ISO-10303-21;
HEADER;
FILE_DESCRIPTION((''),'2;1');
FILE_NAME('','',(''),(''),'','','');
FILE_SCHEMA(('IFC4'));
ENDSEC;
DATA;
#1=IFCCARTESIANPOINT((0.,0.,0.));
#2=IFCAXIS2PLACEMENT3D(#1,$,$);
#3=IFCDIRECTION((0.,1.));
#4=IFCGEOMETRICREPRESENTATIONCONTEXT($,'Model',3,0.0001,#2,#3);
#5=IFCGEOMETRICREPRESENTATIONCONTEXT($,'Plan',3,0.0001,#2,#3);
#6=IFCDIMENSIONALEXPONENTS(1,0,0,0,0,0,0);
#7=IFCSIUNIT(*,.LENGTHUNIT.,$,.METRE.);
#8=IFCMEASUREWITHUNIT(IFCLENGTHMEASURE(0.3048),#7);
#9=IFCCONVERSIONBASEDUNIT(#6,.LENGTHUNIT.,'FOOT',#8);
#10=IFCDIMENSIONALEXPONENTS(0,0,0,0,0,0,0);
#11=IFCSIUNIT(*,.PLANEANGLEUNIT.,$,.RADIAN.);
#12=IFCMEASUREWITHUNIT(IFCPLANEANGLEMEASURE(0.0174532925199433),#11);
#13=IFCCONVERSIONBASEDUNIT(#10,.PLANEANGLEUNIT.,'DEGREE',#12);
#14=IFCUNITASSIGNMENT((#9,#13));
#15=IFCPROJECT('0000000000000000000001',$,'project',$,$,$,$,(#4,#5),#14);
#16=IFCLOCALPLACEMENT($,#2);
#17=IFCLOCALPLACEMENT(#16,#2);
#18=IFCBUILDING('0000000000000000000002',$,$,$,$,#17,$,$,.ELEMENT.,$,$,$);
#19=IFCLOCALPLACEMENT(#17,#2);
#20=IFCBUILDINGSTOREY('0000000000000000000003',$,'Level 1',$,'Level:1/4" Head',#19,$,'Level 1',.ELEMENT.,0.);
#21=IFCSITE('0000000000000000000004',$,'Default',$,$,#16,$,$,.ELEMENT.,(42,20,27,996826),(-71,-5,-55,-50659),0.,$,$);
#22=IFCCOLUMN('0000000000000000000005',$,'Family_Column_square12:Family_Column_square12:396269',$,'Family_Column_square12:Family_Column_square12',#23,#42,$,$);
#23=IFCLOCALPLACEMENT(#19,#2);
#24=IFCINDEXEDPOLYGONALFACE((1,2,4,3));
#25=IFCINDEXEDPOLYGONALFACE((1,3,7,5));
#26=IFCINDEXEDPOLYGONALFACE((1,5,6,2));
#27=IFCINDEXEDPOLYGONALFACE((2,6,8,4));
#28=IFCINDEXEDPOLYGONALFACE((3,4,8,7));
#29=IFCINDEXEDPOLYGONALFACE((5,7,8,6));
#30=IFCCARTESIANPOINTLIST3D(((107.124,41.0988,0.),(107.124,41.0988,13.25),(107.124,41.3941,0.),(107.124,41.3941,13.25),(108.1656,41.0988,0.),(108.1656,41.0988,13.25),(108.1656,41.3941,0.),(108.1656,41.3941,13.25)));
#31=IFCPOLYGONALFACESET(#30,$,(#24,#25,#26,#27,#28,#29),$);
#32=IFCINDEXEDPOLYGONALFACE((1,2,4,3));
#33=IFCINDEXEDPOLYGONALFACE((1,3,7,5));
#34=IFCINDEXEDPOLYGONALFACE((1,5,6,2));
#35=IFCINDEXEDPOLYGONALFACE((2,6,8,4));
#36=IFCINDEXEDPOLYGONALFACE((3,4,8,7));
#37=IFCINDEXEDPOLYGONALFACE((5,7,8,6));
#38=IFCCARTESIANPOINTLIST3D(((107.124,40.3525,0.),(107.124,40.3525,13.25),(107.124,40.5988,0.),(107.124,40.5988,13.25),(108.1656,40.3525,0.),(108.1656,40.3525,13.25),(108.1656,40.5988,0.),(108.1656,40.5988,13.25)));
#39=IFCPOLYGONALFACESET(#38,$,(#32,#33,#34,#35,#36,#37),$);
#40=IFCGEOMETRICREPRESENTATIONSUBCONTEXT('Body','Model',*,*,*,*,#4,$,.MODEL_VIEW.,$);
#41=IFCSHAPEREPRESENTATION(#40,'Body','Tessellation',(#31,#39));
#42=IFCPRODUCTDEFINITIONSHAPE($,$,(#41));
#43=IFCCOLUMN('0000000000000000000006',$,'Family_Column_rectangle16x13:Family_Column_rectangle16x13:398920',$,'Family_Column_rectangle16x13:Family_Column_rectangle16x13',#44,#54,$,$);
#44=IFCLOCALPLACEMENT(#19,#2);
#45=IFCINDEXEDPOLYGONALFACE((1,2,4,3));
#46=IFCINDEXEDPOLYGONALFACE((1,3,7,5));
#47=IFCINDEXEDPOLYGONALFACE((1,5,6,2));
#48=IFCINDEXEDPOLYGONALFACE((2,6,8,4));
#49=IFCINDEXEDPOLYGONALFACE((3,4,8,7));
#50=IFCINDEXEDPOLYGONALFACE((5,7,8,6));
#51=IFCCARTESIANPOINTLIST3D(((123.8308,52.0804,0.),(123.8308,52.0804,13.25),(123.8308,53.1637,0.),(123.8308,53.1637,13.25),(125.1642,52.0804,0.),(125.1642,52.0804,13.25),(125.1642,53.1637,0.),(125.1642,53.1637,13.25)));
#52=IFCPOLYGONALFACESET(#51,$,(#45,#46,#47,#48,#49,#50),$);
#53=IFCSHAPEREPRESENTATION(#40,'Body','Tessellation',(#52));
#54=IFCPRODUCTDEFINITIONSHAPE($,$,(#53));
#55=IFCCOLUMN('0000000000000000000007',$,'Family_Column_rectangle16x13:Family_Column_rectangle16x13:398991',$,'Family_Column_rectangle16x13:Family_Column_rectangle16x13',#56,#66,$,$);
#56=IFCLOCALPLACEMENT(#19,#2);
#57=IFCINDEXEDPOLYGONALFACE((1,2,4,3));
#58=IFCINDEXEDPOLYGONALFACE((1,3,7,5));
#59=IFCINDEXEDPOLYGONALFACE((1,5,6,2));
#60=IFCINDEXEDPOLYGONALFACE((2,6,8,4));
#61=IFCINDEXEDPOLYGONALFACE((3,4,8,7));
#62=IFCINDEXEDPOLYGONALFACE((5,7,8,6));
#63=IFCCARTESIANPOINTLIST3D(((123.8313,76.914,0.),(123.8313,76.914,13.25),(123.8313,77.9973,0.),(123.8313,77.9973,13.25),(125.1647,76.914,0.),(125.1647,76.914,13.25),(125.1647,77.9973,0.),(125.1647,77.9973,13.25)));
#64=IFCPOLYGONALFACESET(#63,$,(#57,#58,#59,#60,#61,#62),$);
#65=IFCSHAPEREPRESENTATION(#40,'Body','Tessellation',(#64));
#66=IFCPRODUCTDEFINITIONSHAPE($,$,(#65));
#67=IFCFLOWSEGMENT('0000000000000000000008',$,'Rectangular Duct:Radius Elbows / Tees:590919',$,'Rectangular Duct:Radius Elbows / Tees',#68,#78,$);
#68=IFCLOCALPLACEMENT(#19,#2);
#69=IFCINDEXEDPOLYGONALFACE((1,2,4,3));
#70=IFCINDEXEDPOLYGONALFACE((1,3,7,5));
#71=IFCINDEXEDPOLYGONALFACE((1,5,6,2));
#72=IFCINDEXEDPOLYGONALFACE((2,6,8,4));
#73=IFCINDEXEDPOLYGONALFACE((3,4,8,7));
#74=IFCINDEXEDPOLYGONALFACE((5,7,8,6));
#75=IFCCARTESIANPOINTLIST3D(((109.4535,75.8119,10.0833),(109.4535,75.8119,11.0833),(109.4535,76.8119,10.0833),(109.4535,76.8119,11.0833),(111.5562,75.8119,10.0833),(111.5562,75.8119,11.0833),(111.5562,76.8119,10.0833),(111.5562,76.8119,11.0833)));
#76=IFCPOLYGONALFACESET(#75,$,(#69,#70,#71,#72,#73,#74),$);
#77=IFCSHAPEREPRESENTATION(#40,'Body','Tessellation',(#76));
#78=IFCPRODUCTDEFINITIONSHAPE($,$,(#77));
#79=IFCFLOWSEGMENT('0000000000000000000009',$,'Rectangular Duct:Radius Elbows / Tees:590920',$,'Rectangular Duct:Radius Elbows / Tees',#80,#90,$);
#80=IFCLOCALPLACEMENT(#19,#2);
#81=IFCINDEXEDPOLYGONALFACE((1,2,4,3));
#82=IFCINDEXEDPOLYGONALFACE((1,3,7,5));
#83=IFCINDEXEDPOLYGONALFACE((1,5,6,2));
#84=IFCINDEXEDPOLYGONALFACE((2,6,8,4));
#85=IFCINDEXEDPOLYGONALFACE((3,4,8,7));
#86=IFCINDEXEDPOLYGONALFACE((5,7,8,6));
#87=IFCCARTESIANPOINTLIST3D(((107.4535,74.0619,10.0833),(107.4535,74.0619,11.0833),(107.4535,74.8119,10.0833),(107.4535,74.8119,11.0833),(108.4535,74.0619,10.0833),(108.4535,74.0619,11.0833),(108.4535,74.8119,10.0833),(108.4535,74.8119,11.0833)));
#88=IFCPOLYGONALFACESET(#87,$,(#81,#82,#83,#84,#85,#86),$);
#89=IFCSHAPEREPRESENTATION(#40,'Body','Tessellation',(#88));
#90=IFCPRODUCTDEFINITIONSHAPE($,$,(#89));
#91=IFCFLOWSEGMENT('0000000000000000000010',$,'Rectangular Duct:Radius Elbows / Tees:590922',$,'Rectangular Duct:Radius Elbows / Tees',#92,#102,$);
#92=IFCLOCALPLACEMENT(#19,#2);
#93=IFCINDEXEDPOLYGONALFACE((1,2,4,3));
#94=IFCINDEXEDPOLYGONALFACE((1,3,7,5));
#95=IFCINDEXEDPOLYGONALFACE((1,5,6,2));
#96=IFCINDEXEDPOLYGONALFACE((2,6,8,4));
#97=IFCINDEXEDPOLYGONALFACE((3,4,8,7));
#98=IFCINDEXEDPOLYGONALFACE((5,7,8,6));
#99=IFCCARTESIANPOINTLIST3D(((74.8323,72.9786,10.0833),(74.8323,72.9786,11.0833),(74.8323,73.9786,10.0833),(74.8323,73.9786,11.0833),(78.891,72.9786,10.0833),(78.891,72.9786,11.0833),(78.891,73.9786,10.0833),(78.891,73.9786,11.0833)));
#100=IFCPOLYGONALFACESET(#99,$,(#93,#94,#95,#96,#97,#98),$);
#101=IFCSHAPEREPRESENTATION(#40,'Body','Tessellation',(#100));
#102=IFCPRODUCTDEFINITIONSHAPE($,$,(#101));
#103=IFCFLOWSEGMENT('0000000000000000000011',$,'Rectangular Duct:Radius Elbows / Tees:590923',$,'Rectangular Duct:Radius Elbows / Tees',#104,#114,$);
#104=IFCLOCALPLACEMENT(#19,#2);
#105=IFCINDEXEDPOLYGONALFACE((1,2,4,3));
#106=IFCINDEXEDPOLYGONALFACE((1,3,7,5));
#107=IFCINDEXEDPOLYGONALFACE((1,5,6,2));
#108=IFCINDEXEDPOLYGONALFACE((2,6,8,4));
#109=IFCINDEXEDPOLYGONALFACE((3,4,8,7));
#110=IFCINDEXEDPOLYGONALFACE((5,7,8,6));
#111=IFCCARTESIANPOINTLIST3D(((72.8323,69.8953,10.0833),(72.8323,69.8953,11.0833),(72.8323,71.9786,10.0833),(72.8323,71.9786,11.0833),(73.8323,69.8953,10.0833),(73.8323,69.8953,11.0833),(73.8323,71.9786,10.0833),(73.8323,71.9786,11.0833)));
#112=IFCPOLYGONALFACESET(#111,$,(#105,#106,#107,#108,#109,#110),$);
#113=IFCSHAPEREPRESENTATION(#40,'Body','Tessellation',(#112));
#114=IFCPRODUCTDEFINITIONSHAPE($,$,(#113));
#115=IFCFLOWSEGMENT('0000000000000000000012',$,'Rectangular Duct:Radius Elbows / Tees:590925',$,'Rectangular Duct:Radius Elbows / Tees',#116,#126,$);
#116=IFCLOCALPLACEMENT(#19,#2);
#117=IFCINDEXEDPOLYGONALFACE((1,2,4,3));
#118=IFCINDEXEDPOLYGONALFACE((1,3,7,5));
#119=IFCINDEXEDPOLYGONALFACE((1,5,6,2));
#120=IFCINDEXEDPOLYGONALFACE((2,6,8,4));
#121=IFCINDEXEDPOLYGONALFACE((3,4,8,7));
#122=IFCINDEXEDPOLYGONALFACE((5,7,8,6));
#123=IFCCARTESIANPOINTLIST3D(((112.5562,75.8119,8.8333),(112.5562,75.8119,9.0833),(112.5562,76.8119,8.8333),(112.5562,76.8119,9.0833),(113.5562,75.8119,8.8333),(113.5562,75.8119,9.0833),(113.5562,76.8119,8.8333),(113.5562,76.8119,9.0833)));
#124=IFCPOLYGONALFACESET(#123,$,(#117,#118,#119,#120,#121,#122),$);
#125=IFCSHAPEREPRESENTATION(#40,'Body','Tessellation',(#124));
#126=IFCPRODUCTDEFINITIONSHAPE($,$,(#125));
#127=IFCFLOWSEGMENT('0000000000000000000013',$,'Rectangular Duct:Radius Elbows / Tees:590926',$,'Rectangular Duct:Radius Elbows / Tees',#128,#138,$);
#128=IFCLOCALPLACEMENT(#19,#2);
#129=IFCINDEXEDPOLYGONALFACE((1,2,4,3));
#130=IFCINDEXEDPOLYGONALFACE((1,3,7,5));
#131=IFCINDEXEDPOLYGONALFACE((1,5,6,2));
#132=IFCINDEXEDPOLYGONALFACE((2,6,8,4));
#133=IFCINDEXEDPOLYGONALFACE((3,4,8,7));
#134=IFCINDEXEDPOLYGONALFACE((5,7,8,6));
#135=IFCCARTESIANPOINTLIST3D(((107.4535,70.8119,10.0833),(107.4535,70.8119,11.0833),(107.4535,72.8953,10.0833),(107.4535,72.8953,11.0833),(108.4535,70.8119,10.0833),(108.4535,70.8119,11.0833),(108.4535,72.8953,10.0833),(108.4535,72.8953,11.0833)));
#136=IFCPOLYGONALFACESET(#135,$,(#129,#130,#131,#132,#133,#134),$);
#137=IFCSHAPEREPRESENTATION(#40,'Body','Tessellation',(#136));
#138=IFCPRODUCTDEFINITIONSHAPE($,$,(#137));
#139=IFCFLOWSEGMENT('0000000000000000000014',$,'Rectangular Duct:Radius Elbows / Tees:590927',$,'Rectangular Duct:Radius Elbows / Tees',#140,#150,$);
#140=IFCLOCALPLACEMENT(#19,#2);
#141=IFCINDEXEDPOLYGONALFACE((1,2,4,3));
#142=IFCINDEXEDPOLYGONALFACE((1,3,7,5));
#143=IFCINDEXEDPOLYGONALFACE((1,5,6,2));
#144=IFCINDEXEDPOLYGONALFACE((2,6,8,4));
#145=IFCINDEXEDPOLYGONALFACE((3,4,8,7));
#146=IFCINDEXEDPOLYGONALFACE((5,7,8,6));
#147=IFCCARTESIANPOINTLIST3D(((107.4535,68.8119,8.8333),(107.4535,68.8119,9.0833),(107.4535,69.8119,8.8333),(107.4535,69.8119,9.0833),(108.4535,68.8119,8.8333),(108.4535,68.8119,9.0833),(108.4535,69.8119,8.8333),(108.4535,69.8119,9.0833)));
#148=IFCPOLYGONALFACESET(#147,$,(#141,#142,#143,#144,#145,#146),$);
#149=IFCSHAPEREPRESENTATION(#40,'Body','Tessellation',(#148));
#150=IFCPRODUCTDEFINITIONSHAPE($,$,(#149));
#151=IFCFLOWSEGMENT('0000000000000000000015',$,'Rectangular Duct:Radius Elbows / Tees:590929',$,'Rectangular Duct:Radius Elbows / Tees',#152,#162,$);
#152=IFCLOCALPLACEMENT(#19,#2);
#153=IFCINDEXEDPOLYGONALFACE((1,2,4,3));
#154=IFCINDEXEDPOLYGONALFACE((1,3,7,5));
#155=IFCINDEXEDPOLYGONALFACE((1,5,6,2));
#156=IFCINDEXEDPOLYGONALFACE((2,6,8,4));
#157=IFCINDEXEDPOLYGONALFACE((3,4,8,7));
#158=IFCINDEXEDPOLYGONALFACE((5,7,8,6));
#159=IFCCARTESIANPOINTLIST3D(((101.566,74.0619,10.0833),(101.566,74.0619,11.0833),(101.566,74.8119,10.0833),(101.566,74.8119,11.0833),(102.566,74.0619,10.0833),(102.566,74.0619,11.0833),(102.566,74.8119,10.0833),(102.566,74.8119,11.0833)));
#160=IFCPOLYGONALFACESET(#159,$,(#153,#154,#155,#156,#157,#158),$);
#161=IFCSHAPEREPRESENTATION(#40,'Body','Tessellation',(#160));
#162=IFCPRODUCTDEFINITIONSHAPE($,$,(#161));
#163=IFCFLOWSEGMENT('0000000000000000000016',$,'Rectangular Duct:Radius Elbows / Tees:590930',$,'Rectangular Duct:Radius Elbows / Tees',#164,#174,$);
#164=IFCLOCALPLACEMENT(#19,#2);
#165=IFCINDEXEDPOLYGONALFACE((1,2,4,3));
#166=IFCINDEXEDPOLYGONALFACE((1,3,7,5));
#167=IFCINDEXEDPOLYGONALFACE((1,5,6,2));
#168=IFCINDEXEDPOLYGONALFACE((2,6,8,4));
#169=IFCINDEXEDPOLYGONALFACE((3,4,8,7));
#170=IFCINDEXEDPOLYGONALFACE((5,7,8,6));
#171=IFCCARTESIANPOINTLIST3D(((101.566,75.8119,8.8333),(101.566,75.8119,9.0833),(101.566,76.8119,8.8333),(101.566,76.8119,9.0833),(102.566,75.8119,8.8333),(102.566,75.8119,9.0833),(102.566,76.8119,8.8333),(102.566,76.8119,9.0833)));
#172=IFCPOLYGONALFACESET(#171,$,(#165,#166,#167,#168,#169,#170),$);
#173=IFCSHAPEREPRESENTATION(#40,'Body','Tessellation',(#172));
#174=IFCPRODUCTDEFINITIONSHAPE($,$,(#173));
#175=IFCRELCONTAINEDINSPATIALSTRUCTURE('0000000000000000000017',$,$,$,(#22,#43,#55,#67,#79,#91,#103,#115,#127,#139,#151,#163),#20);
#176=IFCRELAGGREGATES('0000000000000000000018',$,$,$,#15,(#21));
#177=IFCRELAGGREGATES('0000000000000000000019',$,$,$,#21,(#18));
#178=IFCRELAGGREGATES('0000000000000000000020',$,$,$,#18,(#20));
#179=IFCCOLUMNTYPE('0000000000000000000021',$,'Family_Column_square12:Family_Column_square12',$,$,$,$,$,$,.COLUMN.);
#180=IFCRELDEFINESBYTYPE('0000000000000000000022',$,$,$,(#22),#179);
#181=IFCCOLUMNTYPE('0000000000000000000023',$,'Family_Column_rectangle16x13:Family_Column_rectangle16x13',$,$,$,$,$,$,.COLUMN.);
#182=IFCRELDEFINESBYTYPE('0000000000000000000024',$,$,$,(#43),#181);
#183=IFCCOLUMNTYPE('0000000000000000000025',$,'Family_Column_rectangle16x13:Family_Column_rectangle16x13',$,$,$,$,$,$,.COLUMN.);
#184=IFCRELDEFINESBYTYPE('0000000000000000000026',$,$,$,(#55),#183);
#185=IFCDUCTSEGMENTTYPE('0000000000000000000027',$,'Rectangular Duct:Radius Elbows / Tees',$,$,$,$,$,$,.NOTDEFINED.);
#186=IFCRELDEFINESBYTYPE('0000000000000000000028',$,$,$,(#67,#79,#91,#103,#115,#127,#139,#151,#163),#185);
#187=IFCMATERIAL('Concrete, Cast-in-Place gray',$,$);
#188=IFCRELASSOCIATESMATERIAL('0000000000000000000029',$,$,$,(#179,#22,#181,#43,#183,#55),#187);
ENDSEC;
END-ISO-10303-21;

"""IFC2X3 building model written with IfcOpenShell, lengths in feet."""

from ifc_helpers import new_model, entity, si_unit, converted_unit, direction, frame, frame_2d, origin, origin_2d_with_axis, place, context, subcontext, project, spatial, rectangle, extrude, source, transform, mapped, material, type_object, type_shapes, element, save


model = new_model("IFC2X3")

# Units and contexts
model_context = context("Model", 3, precision=0.0001, world=origin(), true_north=direction((0.0, 1.0)))
plan_context = context("Plan", 3, precision=0.0001, world=origin(), true_north=direction((0.0, 1.0)))
body_context = subcontext(model_context, "Body", "Model", "MODEL_VIEW")
ifc_project = project(units=[converted_unit("LENGTHUNIT", "FOOT", entity("IfcLengthMeasure", 0.3048), si_unit("LENGTHUNIT", "METRE"), dimensions=[1, 0, 0, 0, 0, 0, 0]), converted_unit("PLANEANGLEUNIT", "DEGREE", entity("IfcPlaneAngleMeasure", 0.0174532925199433), si_unit("PLANEANGLEUNIT", "RADIAN"), dimensions=[0, 0, 0, 0, 0, 0, 0])], contexts=[model_context, plan_context])

# Site, building, storey
site_placement = place(None, origin())
site = spatial("IfcSite", under=ifc_project, at=site_placement, Name="Default", CompositionType="ELEMENT", RefLatitude=(42, 20, 27, 996826), RefLongitude=(-71, -5, -55, -50659), RefElevation=0.0)
building_placement = place(site_placement, origin())
building = spatial("IfcBuilding", under=site, at=building_placement, CompositionType="ELEMENT")
storey_placement = place(building_placement, origin())
storey = spatial("IfcBuildingStorey", under=building, at=storey_placement, Name="Level 1", ObjectType="Level:1/4\" Head", LongName="Level 1", CompositionType="ELEMENT", Elevation=0.0)

# Columns
ifc_material_1 = material(Name="Concrete, Cast-in-Place gray")
column_type_1 = type_object("IfcColumnType", Name="Family_Column_square12:Family_Column_square12", PredefinedType="COLUMN", material=ifc_material_1)
shared_shape_1 = source(origin(), body_context, "Body", "SweptSolid", [
    extrude(rectangle(XDim=0.2953, YDim=1.0417, at=frame_2d((0.0, 0.0), x_axis=(1.0, 0.0))), frame((107.6448, 41.2465, 0.0), z_axis=(0.0, 0.0, 1.0), x_axis=(0.0, -1.0, 0.0)), (0.0, 0.0, 1.0), 13.25),
    extrude(rectangle(XDim=0.2464, YDim=1.0417, at=origin_2d_with_axis()), frame((107.6448, 40.4756, 0.0), z_axis=(0.0, 0.0, 1.0), x_axis=(0.0, 1.0, 0.0)), (0.0, 0.0, 1.0), 13.25),
])
type_shapes(column_type_1, [shared_shape_1])
column_1_placement = place(storey_placement, origin())
element("IfcColumn", 1, at=column_1_placement, inside=storey, type_object=column_type_1, material=ifc_material_1, Name="Family_Column_square12:Family_Column_square12:396269", ObjectType="Family_Column_square12:Family_Column_square12", context=body_context, shape_type="MappedRepresentation", body=[
    mapped(shared_shape_1, transform((0.0, 0.0, 0.0), scale=1.0)),
])
column_type_2 = type_object("IfcColumnType", Name="Family_Column_rectangle16x13:Family_Column_rectangle16x13", PredefinedType="COLUMN", material=ifc_material_1)
shared_shape_2 = source(origin(), body_context, "Body", "SweptSolid", [
    extrude(rectangle(XDim=1.3333, YDim=1.0833, at=frame_2d((0.0, 0.0), x_axis=(1.0, 0.0))), frame((124.4975, 52.622, 0.0), z_axis=(0.0, 0.0, 1.0), x_axis=(-1.0, 0.0, 0.0)), (0.0, 0.0, 1.0), 13.25),
])
type_shapes(column_type_2, [shared_shape_2])
column_2_placement = place(storey_placement, origin())
element("IfcColumn", 2, at=column_2_placement, inside=storey, type_object=column_type_2, material=ifc_material_1, Name="Family_Column_rectangle16x13:Family_Column_rectangle16x13:398920", ObjectType="Family_Column_rectangle16x13:Family_Column_rectangle16x13", context=body_context, shape_type="MappedRepresentation", body=[
    mapped(shared_shape_2, transform((0.0, 0.0, 0.0), scale=1.0)),
])
column_type_3 = type_object("IfcColumnType", Name="Family_Column_rectangle16x13:Family_Column_rectangle16x13", PredefinedType="COLUMN", material=ifc_material_1)
shared_shape_3 = source(origin(), body_context, "Body", "SweptSolid", [
    extrude(rectangle(XDim=1.3333, YDim=1.0833, at=frame_2d((0.0, 0.0), x_axis=(1.0, 0.0))), frame((124.498, 77.4557, 0.0), z_axis=(0.0, 0.0, 1.0), x_axis=(-1.0, 0.0, 0.0)), (0.0, 0.0, 1.0), 13.25),
])
type_shapes(column_type_3, [shared_shape_3])
column_3_placement = place(storey_placement, origin())
element("IfcColumn", 3, at=column_3_placement, inside=storey, type_object=column_type_3, material=ifc_material_1, Name="Family_Column_rectangle16x13:Family_Column_rectangle16x13:398991", ObjectType="Family_Column_rectangle16x13:Family_Column_rectangle16x13", context=body_context, shape_type="MappedRepresentation", body=[
    mapped(shared_shape_3, transform((0.0, 0.0, 0.0), scale=1.0)),
])

# Flow segments
duct_segment_type = type_object("IfcDuctSegmentType", Name="Rectangular Duct:Radius Elbows / Tees", PredefinedType="NOTDEFINED")
flow_segment_1_placement = place(storey_placement, origin())
element("IfcFlowSegment", 4, at=flow_segment_1_placement, inside=storey, type_object=duct_segment_type, Name="Rectangular Duct:Radius Elbows / Tees:590919", ObjectType="Rectangular Duct:Radius Elbows / Tees", context=body_context, shape_type="SweptSolid", body=[
    extrude(rectangle(XDim=2.1027, YDim=1.0, at=frame_2d((0.0, 0.0), x_axis=(1.0, 0.0))), frame((110.5049, 76.3119, 10.0833), z_axis=(0.0, 0.0, 1.0), x_axis=(-1.0, 0.0, 0.0)), (0.0, 0.0, 1.0), 1.0),
])
flow_segment_2_placement = place(storey_placement, origin())
element("IfcFlowSegment", 5, at=flow_segment_2_placement, inside=storey, type_object=duct_segment_type, Name="Rectangular Duct:Radius Elbows / Tees:590920", ObjectType="Rectangular Duct:Radius Elbows / Tees", context=body_context, shape_type="SweptSolid", body=[
    extrude(rectangle(XDim=0.75, YDim=1.0, at=frame_2d((0.0, 0.0), x_axis=(1.0, 0.0))), frame((107.9535, 74.4369, 10.0833), z_axis=(0.0, 0.0, 1.0), x_axis=(0.0, -1.0, 0.0)), (0.0, 0.0, 1.0), 1.0),
])
flow_segment_3_placement = place(storey_placement, origin())
element("IfcFlowSegment", 6, at=flow_segment_3_placement, inside=storey, type_object=duct_segment_type, Name="Rectangular Duct:Radius Elbows / Tees:590922", ObjectType="Rectangular Duct:Radius Elbows / Tees", context=body_context, shape_type="SweptSolid", body=[
    extrude(rectangle(XDim=4.0587, YDim=1.0, at=origin_2d_with_axis()), frame((76.8617, 73.4786, 10.0833), z_axis=(0.0, 0.0, 1.0), x_axis=(-1.0, 0.0, 0.0)), (0.0, 0.0, 1.0), 1.0),
])
flow_segment_4_placement = place(storey_placement, origin())
element("IfcFlowSegment", 7, at=flow_segment_4_placement, inside=storey, type_object=duct_segment_type, Name="Rectangular Duct:Radius Elbows / Tees:590923", ObjectType="Rectangular Duct:Radius Elbows / Tees", context=body_context, shape_type="SweptSolid", body=[
    extrude(rectangle(XDim=2.0833, YDim=1.0, at=frame_2d((0.0, 0.0), x_axis=(1.0, 0.0))), frame((73.3323, 70.9369, 10.0833), z_axis=(0.0, 0.0, 1.0), x_axis=(0.0, -1.0, 0.0)), (0.0, 0.0, 1.0), 1.0),
])
flow_segment_5_placement = place(storey_placement, origin())
element("IfcFlowSegment", 8, at=flow_segment_5_placement, inside=storey, type_object=duct_segment_type, Name="Rectangular Duct:Radius Elbows / Tees:590925", ObjectType="Rectangular Duct:Radius Elbows / Tees", context=body_context, shape_type="SweptSolid", body=[
    extrude(rectangle(XDim=1.0, YDim=1.0, at=origin_2d_with_axis()), frame((113.0562, 76.3119, 8.8333), z_axis=(0.0, 0.0, 1.0), x_axis=(0.0, 1.0, 0.0)), (0.0, 0.0, 1.0), 0.25),
])
flow_segment_6_placement = place(storey_placement, origin())
element("IfcFlowSegment", 9, at=flow_segment_6_placement, inside=storey, type_object=duct_segment_type, Name="Rectangular Duct:Radius Elbows / Tees:590926", ObjectType="Rectangular Duct:Radius Elbows / Tees", context=body_context, shape_type="SweptSolid", body=[
    extrude(rectangle(XDim=2.0833, YDim=1.0, at=origin_2d_with_axis()), frame((107.9535, 71.8536, 10.0833), z_axis=(0.0, 0.0, 1.0), x_axis=(0.0, 1.0, 0.0)), (0.0, 0.0, 1.0), 1.0),
])
flow_segment_7_placement = place(storey_placement, origin())
element("IfcFlowSegment", 10, at=flow_segment_7_placement, inside=storey, type_object=duct_segment_type, Name="Rectangular Duct:Radius Elbows / Tees:590927", ObjectType="Rectangular Duct:Radius Elbows / Tees", context=body_context, shape_type="SweptSolid", body=[
    extrude(rectangle(XDim=1.0, YDim=1.0, at=origin_2d_with_axis()), frame((107.9535, 69.3119, 8.8333), z_axis=(0.0, 0.0, 1.0), x_axis=(0.0, 1.0, 0.0)), (0.0, 0.0, 1.0), 0.25),
])
flow_segment_8_placement = place(storey_placement, origin())
element("IfcFlowSegment", 11, at=flow_segment_8_placement, inside=storey, type_object=duct_segment_type, Name="Rectangular Duct:Radius Elbows / Tees:590929", ObjectType="Rectangular Duct:Radius Elbows / Tees", context=body_context, shape_type="SweptSolid", body=[
    extrude(rectangle(XDim=0.75, YDim=1.0, at=frame_2d((0.0, 0.0), x_axis=(1.0, 0.0))), frame((102.066, 74.4369, 10.0833), z_axis=(0.0, 0.0, 1.0), x_axis=(0.0, 1.0, 0.0)), (0.0, 0.0, 1.0), 1.0),
])
flow_segment_9_placement = place(storey_placement, origin())
element("IfcFlowSegment", 12, at=flow_segment_9_placement, inside=storey, type_object=duct_segment_type, Name="Rectangular Duct:Radius Elbows / Tees:590930", ObjectType="Rectangular Duct:Radius Elbows / Tees", context=body_context, shape_type="SweptSolid", body=[
    extrude(rectangle(XDim=1.0, YDim=1.0, at=origin_2d_with_axis()), frame((102.066, 76.3119, 8.8333), z_axis=(0.0, 0.0, 1.0), x_axis=(0.0, 1.0, 0.0)), (0.0, 0.0, 1.0), 0.25),
])

save(model, "model.ifc")
